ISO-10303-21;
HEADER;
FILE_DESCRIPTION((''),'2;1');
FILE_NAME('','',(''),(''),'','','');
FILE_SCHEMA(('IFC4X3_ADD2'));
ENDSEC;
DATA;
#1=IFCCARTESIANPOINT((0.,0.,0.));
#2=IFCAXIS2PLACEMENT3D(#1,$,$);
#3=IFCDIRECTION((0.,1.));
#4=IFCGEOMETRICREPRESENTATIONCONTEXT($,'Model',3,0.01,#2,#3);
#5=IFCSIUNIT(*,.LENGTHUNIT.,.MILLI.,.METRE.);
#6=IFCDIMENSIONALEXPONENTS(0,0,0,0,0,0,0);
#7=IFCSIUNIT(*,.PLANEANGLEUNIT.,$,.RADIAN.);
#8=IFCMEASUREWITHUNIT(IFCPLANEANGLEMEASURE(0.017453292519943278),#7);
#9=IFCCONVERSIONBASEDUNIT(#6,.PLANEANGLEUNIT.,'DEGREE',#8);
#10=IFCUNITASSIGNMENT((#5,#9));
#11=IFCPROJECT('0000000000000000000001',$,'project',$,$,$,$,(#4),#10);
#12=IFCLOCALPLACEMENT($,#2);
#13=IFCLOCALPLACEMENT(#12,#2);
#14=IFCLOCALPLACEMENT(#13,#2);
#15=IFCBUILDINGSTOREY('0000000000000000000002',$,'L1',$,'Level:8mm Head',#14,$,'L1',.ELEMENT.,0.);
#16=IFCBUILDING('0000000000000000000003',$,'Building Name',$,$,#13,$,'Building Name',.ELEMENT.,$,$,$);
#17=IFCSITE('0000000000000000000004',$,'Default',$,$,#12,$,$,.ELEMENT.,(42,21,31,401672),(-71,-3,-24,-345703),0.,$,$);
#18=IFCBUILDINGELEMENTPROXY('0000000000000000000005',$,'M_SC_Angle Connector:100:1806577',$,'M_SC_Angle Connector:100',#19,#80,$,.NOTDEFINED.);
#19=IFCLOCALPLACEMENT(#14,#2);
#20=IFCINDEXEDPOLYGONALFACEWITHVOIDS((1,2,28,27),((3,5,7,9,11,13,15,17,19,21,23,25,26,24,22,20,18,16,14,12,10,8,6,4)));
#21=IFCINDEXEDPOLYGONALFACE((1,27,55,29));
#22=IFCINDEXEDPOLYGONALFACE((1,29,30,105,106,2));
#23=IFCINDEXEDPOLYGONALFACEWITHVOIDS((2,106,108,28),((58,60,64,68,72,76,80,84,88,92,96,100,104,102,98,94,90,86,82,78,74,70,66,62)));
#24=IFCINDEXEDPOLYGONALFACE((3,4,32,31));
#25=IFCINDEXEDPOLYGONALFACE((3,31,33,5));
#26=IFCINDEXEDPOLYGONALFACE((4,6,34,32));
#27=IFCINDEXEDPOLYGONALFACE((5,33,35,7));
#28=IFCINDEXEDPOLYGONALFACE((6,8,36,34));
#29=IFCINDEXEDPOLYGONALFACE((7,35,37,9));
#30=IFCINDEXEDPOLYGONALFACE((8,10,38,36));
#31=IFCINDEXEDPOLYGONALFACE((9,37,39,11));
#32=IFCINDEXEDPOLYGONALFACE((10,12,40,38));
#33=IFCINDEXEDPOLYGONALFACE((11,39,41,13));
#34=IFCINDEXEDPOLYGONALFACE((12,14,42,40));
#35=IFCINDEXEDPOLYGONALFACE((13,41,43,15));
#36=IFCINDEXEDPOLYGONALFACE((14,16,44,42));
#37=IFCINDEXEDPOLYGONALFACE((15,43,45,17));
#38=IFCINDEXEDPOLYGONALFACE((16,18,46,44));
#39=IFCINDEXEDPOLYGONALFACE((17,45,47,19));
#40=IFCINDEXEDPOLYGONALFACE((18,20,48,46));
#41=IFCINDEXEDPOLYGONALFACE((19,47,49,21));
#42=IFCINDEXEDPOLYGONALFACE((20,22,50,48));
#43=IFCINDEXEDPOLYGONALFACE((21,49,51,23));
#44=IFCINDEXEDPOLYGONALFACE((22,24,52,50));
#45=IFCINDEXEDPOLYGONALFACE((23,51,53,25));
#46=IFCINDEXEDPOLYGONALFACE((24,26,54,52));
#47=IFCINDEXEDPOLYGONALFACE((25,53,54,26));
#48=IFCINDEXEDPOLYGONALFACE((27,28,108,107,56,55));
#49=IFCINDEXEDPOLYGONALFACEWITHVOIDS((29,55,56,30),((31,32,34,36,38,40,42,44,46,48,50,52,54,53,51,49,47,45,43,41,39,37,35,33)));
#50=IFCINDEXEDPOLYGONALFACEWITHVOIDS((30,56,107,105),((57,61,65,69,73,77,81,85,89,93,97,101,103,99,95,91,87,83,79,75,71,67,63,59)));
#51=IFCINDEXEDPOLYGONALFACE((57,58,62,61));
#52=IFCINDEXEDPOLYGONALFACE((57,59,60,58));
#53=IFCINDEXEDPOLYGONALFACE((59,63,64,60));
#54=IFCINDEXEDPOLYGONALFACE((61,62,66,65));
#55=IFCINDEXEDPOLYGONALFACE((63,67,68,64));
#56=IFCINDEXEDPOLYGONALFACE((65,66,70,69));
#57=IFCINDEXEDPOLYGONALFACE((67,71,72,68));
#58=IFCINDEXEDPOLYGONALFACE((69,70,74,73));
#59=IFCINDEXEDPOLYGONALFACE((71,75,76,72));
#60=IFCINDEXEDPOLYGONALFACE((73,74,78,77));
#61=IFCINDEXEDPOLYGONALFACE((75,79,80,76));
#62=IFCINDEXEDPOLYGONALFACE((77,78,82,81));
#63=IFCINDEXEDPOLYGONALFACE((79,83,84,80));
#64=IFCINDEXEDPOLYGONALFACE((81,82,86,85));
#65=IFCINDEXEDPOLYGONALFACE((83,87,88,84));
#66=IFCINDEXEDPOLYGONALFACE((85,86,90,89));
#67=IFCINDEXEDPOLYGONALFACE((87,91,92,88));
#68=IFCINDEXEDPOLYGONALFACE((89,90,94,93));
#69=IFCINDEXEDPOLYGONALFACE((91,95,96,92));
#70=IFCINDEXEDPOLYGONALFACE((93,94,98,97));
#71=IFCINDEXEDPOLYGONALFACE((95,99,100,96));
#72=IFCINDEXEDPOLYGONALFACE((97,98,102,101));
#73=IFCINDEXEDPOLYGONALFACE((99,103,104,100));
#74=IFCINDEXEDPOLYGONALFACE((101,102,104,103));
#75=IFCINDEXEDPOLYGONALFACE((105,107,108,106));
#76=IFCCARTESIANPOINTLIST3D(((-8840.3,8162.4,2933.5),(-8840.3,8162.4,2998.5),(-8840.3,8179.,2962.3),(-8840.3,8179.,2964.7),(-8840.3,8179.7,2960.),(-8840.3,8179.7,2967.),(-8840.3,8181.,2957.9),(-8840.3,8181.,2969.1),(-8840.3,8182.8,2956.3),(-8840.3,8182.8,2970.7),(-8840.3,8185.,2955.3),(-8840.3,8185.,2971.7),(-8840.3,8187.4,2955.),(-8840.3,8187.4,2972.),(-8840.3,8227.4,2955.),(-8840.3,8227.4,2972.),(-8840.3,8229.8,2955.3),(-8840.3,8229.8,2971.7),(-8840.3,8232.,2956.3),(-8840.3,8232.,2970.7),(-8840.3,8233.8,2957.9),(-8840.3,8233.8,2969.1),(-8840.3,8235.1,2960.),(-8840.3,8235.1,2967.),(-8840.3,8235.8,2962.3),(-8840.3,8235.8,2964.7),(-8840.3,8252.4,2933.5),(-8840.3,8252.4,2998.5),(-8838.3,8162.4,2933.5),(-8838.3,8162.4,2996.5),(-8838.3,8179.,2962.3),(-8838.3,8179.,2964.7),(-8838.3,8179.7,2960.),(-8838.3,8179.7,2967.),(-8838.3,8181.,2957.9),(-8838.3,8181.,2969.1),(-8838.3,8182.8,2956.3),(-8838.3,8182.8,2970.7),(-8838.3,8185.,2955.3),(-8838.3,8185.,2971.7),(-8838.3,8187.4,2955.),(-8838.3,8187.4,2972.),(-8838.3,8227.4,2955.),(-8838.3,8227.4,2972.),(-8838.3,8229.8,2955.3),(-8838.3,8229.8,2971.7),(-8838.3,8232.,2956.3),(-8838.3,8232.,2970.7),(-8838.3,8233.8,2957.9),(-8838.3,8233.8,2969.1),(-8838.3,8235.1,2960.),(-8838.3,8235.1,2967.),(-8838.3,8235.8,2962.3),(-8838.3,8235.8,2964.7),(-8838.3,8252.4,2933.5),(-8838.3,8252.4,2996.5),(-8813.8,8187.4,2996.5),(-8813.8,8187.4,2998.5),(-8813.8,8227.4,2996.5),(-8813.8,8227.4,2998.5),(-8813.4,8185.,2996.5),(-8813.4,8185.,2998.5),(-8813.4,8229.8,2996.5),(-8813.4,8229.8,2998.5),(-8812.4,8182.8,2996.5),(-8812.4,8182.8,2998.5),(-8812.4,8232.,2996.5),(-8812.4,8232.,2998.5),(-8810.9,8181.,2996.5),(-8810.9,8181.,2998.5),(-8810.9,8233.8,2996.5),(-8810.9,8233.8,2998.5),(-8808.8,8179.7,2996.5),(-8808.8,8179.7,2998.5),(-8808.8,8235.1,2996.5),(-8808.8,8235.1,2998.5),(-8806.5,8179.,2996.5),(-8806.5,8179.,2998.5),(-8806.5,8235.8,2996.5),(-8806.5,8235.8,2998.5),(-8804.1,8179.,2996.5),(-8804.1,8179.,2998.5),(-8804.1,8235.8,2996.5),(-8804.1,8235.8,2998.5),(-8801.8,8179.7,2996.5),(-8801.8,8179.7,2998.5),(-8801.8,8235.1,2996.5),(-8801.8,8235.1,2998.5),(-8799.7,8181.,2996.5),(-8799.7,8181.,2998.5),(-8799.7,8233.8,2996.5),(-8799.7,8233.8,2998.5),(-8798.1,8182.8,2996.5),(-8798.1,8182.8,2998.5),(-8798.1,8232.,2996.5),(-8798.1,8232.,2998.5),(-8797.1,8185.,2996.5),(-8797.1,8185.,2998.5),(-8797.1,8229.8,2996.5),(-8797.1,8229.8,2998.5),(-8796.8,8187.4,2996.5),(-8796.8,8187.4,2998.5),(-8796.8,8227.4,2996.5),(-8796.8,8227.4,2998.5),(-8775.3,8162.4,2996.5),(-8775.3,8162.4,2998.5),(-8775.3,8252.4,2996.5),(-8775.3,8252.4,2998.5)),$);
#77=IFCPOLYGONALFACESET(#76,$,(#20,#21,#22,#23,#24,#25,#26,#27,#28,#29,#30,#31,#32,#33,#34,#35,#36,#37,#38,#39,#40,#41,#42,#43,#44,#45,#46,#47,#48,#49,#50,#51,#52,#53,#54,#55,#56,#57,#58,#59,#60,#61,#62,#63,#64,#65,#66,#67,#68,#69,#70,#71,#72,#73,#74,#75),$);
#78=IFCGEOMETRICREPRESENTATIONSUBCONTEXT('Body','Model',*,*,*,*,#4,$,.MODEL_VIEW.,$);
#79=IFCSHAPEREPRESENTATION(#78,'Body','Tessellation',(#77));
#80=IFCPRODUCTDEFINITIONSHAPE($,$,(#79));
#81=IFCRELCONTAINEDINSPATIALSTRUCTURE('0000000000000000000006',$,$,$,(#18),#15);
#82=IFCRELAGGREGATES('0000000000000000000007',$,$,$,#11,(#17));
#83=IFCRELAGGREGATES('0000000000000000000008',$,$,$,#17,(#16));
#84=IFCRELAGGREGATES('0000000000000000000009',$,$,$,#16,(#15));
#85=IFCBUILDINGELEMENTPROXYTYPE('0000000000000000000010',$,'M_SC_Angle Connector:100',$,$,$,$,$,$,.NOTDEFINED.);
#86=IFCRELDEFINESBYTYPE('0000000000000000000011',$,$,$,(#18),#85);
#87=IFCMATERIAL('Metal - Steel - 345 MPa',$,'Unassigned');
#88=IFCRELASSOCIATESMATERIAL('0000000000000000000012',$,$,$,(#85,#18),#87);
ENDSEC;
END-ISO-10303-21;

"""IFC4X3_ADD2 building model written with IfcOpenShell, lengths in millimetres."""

from ifc_helpers import new_model, entity, si_unit, converted_unit, direction, frame, frame_2d, origin, place, context, subcontext, project, spatial, polyline, circle_curve, parameter, trimmed, segment, composite_curve, outline, extrude, source, transform, mapped, material, type_object, type_shapes, element, save


model = new_model("IFC4X3_ADD2")

# Units and contexts
model_context = context("Model", 3, precision=0.01, world=origin(), true_north=direction((0.0, 1.0)))
body_context = subcontext(model_context, "Body", "Model", "MODEL_VIEW")
ifc_project = project(units=[si_unit("LENGTHUNIT", "METRE", prefix="MILLI"), converted_unit("PLANEANGLEUNIT", "DEGREE", entity("IfcPlaneAngleMeasure", 0.017453292519943278), si_unit("PLANEANGLEUNIT", "RADIAN"), dimensions=[0, 0, 0, 0, 0, 0, 0])], contexts=[model_context])

# Site, building, storey
site_placement = place(None, origin())
site = spatial("IfcSite", under=ifc_project, at=site_placement, Name="Default", CompositionType="ELEMENT", RefLatitude=(42, 21, 31, 401672), RefLongitude=(-71, -3, -24, -345703), RefElevation=0.0)
building_placement = place(site_placement, origin())
building = spatial("IfcBuilding", under=site, at=building_placement, Name="Building Name", LongName="Building Name", CompositionType="ELEMENT")
storey_placement = place(building_placement, origin())
storey = spatial("IfcBuildingStorey", under=building, at=storey_placement, Name="L1", ObjectType="Level:8mm Head", LongName="L1", CompositionType="ELEMENT", Elevation=0.0)

# Building element proxy, openings
ifc_material_1 = material(Name="Metal - Steel - 345 MPa", Category="Unassigned")
building_element_proxy_type_1 = type_object("IfcBuildingElementProxyType", Name="M_SC_Angle Connector:100", PredefinedType="NOTDEFINED", material=ifc_material_1)
shared_shape_1 = source(origin(), body_context, "Body", "SweptSolid", [
    extrude(outline(polyline([(-22.3, -42.7), (-20.3, -42.7), (-20.3, 20.3), (42.7, 20.3), (42.7, 22.3), (-22.3, 22.3), (-22.3, -42.7)])), frame((-22.3, -45.0, 22.3), z_axis=(0.0, 1.0, 0.0), x_axis=(0.0, 0.0, 1.0)), (0.0, 0.0, 1.0), 90.0),
])
type_shapes(building_element_proxy_type_1, [shared_shape_1])
proxy_1_placement = place(storey_placement, frame((-8840.3, 8207.4, 2998.5), z_axis=(0.0, 0.0, -1.0), x_axis=(-1.0, 0.0, 0.0)))
proxy_1 = element("IfcBuildingElementProxy", 1, at=proxy_1_placement, inside=storey, type_object=building_element_proxy_type_1, material=ifc_material_1, Name="M_SC_Angle Connector:100:1806577", ObjectType="M_SC_Angle Connector:100", PredefinedType="NOTDEFINED", context=body_context, shape_type="MappedRepresentation", body=[
    mapped(shared_shape_1, transform((0.0, 0.0, 0.0), scale=1.0)),
])
opening_1_placement = place(storey_placement, frame((-8840.3, 8207.4, 2998.5)))
element("IfcOpeningElement", 2, at=opening_1_placement, cuts=proxy_1, PredefinedType="OPENING", context=body_context, shape_type="SweptSolid", body=[
    extrude(outline(composite_curve([segment(trimmed(circle_curve(frame_2d((0.0, 20.0), x_axis=(1.0, 0.0)), 8.5), [parameter(360.0)], [parameter(180.0)], True, "PARAMETER"), True, "CONTINUOUS"), segment(polyline([(-8.5, 20.0), (-8.5, -20.0)]), True, "CONTINUOUS"), segment(trimmed(circle_curve(frame_2d((0.0, -20.0), x_axis=(1.0, 0.0)), 8.5), [parameter(180.0)], [parameter(360.0)], True, "PARAMETER"), True, "CONTINUOUS"), segment(polyline([(8.5, -20.0), (8.5, 20.0)]), True, "CONTINUOUS")], self_intersect=False)), frame((2.0, 0.0, -35.0), z_axis=(-1.0, 0.0, 0.0), x_axis=(0.0, 0.0, -1.0)), (0.0, 0.0, 1.0), 2.0),
])
opening_2_placement = place(storey_placement, frame((-8840.3, 8207.4, 2998.5)))
element("IfcOpeningElement", 3, at=opening_2_placement, cuts=proxy_1, PredefinedType="OPENING", context=body_context, shape_type="SweptSolid", body=[
    extrude(outline(composite_curve([segment(trimmed(circle_curve(frame_2d((0.0, 20.0), x_axis=(1.0, 0.0)), 8.5), [parameter(0.0)], [parameter(180.0)], True, "PARAMETER"), True, "CONTINUOUS"), segment(polyline([(-8.5, 20.0), (-8.5, -20.0)]), True, "CONTINUOUS"), segment(trimmed(circle_curve(frame_2d((0.0, -20.0), x_axis=(1.0, 0.0)), 8.5), [parameter(180.0)], [parameter(0.0)], True, "PARAMETER"), True, "CONTINUOUS"), segment(polyline([(8.5, -20.0), (8.5, 20.0)]), True, "CONTINUOUS")], self_intersect=False)), frame((35.0, 0.0, -2.0), z_axis=(0.0, 0.0, 1.0), x_axis=(-1.0, 0.0, 0.0)), (0.0, 0.0, 1.0), 2.0),
])

save(model, "model.ifc")
